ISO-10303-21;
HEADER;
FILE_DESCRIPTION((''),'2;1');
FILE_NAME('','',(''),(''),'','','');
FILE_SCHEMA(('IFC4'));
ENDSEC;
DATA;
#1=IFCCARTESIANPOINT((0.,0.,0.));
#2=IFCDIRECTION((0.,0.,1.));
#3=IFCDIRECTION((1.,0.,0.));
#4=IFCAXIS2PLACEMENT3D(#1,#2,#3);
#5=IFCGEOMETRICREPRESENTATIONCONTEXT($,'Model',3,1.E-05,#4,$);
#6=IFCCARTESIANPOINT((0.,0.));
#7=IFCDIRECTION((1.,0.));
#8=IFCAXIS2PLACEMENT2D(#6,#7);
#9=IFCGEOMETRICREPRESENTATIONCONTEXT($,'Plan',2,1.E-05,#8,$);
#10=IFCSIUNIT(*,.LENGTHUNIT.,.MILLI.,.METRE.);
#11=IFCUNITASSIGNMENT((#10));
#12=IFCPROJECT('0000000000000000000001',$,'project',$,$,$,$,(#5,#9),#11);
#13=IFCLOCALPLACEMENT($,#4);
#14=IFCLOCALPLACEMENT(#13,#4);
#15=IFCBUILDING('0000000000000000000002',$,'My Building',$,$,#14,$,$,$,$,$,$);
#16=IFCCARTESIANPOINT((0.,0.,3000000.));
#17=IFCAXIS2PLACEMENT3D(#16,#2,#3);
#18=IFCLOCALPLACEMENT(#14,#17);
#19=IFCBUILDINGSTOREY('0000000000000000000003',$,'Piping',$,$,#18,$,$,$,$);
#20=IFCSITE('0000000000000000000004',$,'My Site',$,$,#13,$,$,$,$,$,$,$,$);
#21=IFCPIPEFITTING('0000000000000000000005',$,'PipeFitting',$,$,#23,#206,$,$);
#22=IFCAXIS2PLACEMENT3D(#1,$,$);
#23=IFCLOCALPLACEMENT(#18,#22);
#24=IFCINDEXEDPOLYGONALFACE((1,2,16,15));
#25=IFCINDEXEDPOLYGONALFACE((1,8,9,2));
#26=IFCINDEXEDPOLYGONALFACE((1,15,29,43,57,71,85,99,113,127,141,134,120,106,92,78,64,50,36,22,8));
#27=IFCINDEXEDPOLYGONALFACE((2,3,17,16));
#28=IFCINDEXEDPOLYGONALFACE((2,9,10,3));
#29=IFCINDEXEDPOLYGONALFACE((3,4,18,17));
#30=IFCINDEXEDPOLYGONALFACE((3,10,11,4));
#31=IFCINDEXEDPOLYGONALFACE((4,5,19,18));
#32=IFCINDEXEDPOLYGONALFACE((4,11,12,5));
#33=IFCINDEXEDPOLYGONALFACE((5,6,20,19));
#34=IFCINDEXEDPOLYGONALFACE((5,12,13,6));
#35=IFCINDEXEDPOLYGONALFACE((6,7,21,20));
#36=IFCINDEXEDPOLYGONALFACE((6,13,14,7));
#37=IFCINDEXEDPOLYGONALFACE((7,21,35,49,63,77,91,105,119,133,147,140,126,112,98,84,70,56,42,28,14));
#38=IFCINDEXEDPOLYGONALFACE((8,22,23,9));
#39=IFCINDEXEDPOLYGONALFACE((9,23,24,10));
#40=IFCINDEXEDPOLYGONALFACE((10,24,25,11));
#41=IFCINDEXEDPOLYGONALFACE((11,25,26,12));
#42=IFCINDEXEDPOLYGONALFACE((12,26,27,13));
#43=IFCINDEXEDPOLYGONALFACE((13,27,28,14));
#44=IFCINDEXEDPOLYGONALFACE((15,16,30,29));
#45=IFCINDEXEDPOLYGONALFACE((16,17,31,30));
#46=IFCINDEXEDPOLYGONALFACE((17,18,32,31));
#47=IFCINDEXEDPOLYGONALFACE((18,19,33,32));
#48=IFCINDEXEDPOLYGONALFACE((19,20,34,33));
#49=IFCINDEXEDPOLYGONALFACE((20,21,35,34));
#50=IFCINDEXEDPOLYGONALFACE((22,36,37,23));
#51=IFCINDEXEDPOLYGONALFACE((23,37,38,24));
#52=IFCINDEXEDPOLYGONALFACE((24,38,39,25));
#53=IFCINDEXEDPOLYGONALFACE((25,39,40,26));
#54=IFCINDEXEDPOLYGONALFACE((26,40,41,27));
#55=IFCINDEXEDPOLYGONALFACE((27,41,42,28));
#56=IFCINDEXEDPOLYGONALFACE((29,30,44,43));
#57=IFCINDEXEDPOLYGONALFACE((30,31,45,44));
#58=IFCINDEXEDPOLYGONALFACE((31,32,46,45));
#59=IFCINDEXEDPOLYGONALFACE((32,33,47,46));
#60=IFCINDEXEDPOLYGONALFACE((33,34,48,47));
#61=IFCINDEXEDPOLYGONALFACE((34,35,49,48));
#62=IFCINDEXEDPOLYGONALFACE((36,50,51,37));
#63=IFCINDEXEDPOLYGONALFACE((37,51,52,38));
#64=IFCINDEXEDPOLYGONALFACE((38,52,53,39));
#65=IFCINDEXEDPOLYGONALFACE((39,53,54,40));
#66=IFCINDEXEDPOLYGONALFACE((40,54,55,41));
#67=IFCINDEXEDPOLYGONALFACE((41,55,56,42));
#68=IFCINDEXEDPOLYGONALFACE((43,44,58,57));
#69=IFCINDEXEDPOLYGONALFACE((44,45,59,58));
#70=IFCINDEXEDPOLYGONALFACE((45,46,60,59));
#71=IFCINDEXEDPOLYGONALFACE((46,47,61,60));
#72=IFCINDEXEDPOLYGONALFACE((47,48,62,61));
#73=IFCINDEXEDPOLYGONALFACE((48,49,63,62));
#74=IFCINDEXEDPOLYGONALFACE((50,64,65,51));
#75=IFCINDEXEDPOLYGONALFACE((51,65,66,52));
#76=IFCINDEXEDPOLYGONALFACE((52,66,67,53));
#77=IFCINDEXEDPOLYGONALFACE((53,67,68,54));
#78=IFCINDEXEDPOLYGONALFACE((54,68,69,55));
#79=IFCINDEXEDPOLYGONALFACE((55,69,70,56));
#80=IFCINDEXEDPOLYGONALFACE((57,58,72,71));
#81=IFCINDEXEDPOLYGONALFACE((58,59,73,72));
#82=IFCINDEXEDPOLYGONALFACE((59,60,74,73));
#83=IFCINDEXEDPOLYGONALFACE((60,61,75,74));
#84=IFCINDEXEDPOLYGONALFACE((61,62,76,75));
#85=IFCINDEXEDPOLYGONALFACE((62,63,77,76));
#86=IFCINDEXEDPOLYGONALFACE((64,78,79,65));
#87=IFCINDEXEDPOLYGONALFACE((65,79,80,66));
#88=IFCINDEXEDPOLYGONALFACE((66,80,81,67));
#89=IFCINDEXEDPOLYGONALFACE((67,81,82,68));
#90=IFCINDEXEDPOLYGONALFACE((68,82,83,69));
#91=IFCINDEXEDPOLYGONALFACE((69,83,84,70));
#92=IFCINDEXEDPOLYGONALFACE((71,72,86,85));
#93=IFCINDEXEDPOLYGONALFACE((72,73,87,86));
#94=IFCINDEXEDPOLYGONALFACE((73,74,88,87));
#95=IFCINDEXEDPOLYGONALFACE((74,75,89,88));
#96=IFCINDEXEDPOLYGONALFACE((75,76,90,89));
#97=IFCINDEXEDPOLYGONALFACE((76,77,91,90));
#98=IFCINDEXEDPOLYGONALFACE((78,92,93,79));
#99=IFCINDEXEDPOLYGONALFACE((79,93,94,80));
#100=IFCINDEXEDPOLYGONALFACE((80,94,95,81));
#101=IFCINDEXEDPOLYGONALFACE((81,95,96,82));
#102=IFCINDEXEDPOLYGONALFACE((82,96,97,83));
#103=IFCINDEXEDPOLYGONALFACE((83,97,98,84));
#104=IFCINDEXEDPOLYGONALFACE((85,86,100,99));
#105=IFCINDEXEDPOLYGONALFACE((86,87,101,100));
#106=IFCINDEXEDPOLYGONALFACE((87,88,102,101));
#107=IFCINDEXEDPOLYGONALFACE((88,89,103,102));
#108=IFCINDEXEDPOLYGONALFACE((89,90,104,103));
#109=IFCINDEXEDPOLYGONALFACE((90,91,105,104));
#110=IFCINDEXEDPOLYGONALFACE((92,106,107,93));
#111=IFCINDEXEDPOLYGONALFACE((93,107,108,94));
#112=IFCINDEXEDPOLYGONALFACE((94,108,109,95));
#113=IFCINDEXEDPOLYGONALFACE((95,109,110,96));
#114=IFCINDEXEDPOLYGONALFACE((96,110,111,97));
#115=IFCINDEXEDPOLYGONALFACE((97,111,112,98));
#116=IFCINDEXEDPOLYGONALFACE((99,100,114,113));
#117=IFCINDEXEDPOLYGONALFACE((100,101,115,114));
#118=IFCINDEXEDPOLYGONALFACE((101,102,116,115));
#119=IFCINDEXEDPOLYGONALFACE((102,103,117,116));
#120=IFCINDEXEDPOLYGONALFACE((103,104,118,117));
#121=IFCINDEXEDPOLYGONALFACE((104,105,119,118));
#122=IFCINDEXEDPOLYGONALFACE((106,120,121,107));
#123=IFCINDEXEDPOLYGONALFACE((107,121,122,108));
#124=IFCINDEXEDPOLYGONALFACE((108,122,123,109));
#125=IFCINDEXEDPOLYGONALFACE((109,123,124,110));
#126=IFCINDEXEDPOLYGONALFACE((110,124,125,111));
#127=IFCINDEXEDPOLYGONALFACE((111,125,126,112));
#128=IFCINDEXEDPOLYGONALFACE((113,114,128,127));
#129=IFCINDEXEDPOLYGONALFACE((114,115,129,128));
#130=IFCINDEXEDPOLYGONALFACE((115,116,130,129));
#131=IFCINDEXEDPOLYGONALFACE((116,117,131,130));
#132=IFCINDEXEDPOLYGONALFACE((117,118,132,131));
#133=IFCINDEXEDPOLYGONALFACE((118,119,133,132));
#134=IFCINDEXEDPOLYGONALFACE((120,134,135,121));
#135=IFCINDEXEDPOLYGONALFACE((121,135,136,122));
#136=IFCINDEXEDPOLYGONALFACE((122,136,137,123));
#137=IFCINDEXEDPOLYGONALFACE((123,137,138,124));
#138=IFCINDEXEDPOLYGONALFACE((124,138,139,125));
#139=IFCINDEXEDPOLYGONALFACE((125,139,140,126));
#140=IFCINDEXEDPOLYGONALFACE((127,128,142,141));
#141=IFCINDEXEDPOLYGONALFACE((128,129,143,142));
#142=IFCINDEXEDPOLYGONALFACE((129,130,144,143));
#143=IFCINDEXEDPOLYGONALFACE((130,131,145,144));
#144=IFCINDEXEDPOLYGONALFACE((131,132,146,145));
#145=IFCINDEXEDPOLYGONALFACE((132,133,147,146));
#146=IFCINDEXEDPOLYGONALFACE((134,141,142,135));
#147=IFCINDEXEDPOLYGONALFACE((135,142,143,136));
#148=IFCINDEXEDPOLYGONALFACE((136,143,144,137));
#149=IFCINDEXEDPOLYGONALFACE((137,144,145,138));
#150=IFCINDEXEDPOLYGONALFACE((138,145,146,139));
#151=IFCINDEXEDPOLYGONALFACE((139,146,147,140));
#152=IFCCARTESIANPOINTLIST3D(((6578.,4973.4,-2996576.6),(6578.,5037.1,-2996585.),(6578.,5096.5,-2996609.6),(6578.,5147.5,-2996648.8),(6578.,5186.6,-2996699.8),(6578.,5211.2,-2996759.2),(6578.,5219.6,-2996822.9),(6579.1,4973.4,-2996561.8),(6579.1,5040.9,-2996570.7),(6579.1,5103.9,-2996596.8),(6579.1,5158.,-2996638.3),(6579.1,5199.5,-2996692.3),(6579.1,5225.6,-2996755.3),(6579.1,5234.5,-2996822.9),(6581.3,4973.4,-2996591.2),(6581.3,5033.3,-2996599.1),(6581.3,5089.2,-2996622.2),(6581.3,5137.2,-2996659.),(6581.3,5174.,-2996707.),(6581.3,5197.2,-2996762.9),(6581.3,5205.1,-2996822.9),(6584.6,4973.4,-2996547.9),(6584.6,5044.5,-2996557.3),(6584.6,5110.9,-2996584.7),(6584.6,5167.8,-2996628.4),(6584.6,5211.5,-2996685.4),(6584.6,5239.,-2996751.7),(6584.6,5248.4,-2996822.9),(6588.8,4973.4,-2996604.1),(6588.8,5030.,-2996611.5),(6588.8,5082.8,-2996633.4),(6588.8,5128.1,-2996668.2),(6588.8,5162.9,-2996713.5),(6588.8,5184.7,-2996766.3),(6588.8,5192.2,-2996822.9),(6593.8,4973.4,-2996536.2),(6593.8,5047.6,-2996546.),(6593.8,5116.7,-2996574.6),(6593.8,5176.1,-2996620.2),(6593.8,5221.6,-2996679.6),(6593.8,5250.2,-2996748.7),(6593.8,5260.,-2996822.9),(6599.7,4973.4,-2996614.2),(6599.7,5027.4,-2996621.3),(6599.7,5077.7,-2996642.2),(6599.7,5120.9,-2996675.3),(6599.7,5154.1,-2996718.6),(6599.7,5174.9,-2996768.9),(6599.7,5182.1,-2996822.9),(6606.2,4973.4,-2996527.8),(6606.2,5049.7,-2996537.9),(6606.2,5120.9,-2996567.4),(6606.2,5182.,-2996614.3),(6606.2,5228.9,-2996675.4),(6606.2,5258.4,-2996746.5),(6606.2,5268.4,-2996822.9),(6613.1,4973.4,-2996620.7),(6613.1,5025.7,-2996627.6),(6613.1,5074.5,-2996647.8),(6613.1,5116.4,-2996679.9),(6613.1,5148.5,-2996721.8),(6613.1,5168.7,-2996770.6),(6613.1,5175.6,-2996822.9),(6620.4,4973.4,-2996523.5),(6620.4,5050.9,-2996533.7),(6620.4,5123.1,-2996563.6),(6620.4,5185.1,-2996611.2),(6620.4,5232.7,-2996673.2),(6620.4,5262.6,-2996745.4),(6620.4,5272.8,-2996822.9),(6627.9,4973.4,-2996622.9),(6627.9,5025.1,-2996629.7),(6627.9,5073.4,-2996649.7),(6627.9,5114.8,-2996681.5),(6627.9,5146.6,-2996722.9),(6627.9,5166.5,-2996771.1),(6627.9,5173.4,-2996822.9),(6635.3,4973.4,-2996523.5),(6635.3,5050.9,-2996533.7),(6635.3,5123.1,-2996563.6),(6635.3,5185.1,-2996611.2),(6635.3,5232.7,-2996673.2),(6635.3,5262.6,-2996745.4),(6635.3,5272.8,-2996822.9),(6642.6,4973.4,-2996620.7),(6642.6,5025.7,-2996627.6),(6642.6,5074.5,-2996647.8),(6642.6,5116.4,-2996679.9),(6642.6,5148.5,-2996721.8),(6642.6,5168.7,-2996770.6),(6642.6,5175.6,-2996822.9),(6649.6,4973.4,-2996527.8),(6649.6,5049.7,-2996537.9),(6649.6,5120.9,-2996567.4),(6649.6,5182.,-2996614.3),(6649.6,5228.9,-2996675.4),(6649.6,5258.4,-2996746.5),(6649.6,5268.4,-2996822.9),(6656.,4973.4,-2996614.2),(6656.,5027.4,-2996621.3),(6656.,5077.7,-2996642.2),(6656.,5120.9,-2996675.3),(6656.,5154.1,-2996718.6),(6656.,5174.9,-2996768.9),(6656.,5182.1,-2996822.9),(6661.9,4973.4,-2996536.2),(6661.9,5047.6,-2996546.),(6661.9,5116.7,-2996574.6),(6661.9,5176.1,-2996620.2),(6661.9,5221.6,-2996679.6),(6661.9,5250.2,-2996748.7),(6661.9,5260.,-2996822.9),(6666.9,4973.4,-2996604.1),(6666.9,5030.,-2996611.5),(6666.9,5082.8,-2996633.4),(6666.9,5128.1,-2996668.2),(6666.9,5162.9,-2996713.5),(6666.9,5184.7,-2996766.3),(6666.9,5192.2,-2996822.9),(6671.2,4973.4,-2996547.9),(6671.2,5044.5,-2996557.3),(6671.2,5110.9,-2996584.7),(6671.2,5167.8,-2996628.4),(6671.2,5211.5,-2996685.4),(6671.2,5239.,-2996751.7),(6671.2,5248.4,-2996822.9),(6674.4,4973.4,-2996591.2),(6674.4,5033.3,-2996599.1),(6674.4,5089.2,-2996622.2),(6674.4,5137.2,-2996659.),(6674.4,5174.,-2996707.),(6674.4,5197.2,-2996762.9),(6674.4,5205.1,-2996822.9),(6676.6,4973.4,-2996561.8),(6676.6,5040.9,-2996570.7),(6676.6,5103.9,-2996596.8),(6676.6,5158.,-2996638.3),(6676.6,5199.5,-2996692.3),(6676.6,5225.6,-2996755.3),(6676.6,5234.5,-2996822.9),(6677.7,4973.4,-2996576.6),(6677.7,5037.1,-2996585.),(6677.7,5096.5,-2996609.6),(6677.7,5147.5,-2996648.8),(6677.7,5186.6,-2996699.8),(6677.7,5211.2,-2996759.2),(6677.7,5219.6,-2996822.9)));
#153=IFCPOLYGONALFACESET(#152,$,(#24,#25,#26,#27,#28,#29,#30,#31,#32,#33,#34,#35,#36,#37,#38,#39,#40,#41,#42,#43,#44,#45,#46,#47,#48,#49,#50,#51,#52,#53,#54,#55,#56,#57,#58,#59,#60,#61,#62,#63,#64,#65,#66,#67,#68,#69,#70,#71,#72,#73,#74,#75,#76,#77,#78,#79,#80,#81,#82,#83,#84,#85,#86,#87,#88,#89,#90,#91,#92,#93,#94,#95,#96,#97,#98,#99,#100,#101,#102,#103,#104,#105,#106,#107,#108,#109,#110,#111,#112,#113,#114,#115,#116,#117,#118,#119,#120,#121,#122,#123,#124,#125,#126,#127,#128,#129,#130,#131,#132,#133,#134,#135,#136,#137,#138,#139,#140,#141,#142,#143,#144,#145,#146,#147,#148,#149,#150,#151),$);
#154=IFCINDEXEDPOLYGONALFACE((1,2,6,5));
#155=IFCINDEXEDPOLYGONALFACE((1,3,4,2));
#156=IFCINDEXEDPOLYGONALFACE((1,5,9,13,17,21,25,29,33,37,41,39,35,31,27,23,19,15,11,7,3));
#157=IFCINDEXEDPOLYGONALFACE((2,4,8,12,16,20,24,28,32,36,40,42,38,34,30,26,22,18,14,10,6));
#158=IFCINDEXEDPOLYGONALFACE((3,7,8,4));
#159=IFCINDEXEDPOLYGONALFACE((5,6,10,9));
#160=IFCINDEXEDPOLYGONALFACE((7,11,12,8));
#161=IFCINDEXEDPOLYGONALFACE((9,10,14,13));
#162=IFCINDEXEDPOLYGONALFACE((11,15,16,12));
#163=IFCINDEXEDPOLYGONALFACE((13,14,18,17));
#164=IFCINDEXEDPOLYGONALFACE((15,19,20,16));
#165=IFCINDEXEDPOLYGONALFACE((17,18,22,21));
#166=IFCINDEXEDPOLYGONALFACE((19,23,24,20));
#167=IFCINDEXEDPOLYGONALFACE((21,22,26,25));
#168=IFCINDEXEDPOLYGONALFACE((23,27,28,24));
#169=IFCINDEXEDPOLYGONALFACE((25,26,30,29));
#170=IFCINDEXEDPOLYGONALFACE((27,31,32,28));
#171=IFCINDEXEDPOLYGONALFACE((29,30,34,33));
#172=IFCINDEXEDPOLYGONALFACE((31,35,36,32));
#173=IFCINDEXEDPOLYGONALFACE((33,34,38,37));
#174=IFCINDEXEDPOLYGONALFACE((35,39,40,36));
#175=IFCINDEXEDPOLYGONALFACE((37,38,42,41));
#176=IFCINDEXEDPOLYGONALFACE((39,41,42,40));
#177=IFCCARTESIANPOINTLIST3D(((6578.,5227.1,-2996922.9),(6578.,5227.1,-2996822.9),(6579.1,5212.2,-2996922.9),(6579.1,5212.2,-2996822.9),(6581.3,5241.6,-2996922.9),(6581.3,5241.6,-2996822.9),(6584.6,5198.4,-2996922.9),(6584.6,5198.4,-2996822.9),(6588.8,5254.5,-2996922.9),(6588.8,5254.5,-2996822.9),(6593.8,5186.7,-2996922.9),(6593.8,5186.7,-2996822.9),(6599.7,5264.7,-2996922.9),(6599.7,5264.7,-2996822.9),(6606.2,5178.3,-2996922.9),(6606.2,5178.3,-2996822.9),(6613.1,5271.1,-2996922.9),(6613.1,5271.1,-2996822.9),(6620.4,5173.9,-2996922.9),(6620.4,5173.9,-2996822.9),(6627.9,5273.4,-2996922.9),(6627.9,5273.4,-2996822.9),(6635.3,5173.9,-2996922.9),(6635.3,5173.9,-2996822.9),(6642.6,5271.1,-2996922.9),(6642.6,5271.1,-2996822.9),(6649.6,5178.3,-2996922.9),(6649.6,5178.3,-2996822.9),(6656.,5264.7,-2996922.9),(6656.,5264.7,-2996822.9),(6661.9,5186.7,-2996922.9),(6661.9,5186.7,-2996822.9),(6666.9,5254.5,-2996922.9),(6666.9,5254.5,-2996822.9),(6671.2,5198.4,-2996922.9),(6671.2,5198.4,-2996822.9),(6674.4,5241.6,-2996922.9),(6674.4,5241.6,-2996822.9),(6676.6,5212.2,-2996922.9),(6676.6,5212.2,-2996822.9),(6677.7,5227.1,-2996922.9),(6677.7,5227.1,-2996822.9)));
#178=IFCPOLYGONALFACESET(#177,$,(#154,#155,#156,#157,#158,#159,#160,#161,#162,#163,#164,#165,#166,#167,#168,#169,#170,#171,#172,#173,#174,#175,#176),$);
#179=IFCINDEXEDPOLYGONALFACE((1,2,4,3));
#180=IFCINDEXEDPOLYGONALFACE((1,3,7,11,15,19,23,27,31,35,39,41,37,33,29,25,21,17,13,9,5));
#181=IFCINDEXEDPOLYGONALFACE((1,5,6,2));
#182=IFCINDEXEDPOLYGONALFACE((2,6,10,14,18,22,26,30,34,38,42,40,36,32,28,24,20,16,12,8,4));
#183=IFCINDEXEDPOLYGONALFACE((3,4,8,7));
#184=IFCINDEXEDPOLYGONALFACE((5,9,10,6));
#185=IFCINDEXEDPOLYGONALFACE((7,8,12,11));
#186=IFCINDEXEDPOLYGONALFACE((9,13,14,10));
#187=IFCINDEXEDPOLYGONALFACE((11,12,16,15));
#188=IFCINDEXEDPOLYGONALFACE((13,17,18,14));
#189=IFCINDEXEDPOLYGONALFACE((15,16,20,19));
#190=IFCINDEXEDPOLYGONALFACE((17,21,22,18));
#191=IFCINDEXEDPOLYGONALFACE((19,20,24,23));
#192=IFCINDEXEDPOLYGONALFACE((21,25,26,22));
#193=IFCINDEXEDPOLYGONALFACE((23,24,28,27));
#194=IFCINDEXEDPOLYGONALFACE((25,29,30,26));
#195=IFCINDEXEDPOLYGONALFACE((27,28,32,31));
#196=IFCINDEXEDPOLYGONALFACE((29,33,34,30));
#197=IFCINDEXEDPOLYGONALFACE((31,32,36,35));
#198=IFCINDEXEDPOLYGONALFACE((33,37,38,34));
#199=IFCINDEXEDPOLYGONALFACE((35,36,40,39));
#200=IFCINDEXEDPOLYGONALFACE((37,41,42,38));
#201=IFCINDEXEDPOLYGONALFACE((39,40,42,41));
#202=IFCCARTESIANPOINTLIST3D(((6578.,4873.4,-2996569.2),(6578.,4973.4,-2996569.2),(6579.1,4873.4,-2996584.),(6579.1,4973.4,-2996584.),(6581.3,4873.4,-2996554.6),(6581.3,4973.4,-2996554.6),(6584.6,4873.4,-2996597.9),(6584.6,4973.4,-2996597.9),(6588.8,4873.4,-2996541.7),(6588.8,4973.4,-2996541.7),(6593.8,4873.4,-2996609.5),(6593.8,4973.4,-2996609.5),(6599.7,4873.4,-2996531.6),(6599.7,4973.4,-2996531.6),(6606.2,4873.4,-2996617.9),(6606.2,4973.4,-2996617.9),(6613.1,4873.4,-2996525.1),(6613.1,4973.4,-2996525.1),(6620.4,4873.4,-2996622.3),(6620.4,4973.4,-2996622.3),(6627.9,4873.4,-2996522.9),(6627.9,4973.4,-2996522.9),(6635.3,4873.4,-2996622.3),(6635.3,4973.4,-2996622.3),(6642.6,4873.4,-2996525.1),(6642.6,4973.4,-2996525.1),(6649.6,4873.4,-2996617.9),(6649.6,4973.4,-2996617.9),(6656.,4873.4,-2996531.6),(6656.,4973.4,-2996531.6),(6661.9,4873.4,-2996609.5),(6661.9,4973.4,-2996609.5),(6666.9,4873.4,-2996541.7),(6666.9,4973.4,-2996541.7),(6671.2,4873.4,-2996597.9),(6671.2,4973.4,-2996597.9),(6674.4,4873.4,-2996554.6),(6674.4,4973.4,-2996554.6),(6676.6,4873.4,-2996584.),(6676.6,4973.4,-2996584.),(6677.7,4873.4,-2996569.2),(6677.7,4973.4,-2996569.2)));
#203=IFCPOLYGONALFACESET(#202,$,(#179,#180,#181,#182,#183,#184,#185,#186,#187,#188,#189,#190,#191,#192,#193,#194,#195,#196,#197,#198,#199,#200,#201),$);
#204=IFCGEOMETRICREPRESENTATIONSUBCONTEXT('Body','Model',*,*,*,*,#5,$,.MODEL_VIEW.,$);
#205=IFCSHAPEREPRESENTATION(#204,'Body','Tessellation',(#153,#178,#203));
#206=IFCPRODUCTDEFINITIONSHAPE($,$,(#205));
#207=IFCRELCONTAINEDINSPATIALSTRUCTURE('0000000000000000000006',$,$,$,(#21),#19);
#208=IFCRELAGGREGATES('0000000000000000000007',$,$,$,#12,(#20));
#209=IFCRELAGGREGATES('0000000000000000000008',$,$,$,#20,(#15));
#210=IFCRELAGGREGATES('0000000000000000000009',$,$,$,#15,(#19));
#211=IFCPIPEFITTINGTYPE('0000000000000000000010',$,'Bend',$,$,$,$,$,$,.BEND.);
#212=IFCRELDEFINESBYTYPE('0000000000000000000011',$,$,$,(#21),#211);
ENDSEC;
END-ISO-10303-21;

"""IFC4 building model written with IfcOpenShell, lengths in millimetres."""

from ifc_helpers import new_model, entity, si_unit, frame, origin_with_axes, origin_2d_with_axis, place, context, subcontext, project, spatial, circle, extrude, source, transform, mapped, type_object, type_shapes, element, save


model = new_model("IFC4")

# Units and contexts
model_context = context("Model", 3, precision=1e-05, world=origin_with_axes())
plan_context = context("Plan", 2, precision=1e-05, world=origin_2d_with_axis())
body_context = subcontext(model_context, "Body", "Model", "MODEL_VIEW")
ifc_project = project(units=[si_unit("LENGTHUNIT", "METRE", prefix="MILLI")], contexts=[model_context, plan_context])

# Site, building, storey
site_placement = place(None, origin_with_axes())
site = spatial("IfcSite", under=ifc_project, at=site_placement, Name="My Site")
building_placement = place(site_placement, origin_with_axes())
building = spatial("IfcBuilding", under=site, at=building_placement, Name="My Building")
storey_placement = place(building_placement, frame((0.0, 0.0, 3000000.0), z_axis=(0.0, 0.0, 1.0), x_axis=(1.0, 0.0, 0.0)))
storey = spatial("IfcBuildingStorey", under=building, at=storey_placement, Name="Piping")

# Shared definitions
pipe_fitting_type_1 = type_object("IfcPipeFittingType", Name="Bend", PredefinedType="BEND")
shared_shape_1 = source(origin_with_axes(), body_context, "Body", "SolidModel", [
    entity("IfcSweptDiskSolid", entity("IfcIndexedPolyCurve", entity("IfcCartesianPointList3D", [[0.0, 0.0, -100.0], [-73.2, 0.0, -276.8], [-250.0, 0.0, -350.0]]), [entity("IfcArcIndex", [1, 2, 3])]), 50.0),
    extrude(circle(Radius=50.0), origin_with_axes(), (0.0, 0.0, -1.0), 100.0),
    extrude(circle(Radius=50.0), frame((-250.0, 0.0, -350.0), z_axis=(-1.0, 0.0, 0.0), x_axis=(0.0, 0.0, -1.0)), (0.0, 0.0, 1.0), 100.0),
])
type_shapes(pipe_fitting_type_1, [shared_shape_1])

# Pipe fitting
for number, where, z_axis, x_axis, name in (
    (1, (6627.9, 5223.4, -2996922.9), (0.0, 0.0, -1.0), (0.0, 1.0, 0.0), "PipeFitting"),
):
    element("IfcPipeFitting", number, at=place(storey_placement, frame(where, z_axis=z_axis, x_axis=x_axis)), inside=storey, type_object=pipe_fitting_type_1, Name=name, context=body_context, shape_type="MappedRepresentation", body=[
        mapped(shared_shape_1, transform((0.0, 0.0, 0.0), x_axis=(1.0, 0.0, 0.0), y_axis=(0.0, 1.0, 0.0), z_axis=(0.0, 0.0, 1.0), scale=1.0)),
    ])

save(model, "model.ifc")
